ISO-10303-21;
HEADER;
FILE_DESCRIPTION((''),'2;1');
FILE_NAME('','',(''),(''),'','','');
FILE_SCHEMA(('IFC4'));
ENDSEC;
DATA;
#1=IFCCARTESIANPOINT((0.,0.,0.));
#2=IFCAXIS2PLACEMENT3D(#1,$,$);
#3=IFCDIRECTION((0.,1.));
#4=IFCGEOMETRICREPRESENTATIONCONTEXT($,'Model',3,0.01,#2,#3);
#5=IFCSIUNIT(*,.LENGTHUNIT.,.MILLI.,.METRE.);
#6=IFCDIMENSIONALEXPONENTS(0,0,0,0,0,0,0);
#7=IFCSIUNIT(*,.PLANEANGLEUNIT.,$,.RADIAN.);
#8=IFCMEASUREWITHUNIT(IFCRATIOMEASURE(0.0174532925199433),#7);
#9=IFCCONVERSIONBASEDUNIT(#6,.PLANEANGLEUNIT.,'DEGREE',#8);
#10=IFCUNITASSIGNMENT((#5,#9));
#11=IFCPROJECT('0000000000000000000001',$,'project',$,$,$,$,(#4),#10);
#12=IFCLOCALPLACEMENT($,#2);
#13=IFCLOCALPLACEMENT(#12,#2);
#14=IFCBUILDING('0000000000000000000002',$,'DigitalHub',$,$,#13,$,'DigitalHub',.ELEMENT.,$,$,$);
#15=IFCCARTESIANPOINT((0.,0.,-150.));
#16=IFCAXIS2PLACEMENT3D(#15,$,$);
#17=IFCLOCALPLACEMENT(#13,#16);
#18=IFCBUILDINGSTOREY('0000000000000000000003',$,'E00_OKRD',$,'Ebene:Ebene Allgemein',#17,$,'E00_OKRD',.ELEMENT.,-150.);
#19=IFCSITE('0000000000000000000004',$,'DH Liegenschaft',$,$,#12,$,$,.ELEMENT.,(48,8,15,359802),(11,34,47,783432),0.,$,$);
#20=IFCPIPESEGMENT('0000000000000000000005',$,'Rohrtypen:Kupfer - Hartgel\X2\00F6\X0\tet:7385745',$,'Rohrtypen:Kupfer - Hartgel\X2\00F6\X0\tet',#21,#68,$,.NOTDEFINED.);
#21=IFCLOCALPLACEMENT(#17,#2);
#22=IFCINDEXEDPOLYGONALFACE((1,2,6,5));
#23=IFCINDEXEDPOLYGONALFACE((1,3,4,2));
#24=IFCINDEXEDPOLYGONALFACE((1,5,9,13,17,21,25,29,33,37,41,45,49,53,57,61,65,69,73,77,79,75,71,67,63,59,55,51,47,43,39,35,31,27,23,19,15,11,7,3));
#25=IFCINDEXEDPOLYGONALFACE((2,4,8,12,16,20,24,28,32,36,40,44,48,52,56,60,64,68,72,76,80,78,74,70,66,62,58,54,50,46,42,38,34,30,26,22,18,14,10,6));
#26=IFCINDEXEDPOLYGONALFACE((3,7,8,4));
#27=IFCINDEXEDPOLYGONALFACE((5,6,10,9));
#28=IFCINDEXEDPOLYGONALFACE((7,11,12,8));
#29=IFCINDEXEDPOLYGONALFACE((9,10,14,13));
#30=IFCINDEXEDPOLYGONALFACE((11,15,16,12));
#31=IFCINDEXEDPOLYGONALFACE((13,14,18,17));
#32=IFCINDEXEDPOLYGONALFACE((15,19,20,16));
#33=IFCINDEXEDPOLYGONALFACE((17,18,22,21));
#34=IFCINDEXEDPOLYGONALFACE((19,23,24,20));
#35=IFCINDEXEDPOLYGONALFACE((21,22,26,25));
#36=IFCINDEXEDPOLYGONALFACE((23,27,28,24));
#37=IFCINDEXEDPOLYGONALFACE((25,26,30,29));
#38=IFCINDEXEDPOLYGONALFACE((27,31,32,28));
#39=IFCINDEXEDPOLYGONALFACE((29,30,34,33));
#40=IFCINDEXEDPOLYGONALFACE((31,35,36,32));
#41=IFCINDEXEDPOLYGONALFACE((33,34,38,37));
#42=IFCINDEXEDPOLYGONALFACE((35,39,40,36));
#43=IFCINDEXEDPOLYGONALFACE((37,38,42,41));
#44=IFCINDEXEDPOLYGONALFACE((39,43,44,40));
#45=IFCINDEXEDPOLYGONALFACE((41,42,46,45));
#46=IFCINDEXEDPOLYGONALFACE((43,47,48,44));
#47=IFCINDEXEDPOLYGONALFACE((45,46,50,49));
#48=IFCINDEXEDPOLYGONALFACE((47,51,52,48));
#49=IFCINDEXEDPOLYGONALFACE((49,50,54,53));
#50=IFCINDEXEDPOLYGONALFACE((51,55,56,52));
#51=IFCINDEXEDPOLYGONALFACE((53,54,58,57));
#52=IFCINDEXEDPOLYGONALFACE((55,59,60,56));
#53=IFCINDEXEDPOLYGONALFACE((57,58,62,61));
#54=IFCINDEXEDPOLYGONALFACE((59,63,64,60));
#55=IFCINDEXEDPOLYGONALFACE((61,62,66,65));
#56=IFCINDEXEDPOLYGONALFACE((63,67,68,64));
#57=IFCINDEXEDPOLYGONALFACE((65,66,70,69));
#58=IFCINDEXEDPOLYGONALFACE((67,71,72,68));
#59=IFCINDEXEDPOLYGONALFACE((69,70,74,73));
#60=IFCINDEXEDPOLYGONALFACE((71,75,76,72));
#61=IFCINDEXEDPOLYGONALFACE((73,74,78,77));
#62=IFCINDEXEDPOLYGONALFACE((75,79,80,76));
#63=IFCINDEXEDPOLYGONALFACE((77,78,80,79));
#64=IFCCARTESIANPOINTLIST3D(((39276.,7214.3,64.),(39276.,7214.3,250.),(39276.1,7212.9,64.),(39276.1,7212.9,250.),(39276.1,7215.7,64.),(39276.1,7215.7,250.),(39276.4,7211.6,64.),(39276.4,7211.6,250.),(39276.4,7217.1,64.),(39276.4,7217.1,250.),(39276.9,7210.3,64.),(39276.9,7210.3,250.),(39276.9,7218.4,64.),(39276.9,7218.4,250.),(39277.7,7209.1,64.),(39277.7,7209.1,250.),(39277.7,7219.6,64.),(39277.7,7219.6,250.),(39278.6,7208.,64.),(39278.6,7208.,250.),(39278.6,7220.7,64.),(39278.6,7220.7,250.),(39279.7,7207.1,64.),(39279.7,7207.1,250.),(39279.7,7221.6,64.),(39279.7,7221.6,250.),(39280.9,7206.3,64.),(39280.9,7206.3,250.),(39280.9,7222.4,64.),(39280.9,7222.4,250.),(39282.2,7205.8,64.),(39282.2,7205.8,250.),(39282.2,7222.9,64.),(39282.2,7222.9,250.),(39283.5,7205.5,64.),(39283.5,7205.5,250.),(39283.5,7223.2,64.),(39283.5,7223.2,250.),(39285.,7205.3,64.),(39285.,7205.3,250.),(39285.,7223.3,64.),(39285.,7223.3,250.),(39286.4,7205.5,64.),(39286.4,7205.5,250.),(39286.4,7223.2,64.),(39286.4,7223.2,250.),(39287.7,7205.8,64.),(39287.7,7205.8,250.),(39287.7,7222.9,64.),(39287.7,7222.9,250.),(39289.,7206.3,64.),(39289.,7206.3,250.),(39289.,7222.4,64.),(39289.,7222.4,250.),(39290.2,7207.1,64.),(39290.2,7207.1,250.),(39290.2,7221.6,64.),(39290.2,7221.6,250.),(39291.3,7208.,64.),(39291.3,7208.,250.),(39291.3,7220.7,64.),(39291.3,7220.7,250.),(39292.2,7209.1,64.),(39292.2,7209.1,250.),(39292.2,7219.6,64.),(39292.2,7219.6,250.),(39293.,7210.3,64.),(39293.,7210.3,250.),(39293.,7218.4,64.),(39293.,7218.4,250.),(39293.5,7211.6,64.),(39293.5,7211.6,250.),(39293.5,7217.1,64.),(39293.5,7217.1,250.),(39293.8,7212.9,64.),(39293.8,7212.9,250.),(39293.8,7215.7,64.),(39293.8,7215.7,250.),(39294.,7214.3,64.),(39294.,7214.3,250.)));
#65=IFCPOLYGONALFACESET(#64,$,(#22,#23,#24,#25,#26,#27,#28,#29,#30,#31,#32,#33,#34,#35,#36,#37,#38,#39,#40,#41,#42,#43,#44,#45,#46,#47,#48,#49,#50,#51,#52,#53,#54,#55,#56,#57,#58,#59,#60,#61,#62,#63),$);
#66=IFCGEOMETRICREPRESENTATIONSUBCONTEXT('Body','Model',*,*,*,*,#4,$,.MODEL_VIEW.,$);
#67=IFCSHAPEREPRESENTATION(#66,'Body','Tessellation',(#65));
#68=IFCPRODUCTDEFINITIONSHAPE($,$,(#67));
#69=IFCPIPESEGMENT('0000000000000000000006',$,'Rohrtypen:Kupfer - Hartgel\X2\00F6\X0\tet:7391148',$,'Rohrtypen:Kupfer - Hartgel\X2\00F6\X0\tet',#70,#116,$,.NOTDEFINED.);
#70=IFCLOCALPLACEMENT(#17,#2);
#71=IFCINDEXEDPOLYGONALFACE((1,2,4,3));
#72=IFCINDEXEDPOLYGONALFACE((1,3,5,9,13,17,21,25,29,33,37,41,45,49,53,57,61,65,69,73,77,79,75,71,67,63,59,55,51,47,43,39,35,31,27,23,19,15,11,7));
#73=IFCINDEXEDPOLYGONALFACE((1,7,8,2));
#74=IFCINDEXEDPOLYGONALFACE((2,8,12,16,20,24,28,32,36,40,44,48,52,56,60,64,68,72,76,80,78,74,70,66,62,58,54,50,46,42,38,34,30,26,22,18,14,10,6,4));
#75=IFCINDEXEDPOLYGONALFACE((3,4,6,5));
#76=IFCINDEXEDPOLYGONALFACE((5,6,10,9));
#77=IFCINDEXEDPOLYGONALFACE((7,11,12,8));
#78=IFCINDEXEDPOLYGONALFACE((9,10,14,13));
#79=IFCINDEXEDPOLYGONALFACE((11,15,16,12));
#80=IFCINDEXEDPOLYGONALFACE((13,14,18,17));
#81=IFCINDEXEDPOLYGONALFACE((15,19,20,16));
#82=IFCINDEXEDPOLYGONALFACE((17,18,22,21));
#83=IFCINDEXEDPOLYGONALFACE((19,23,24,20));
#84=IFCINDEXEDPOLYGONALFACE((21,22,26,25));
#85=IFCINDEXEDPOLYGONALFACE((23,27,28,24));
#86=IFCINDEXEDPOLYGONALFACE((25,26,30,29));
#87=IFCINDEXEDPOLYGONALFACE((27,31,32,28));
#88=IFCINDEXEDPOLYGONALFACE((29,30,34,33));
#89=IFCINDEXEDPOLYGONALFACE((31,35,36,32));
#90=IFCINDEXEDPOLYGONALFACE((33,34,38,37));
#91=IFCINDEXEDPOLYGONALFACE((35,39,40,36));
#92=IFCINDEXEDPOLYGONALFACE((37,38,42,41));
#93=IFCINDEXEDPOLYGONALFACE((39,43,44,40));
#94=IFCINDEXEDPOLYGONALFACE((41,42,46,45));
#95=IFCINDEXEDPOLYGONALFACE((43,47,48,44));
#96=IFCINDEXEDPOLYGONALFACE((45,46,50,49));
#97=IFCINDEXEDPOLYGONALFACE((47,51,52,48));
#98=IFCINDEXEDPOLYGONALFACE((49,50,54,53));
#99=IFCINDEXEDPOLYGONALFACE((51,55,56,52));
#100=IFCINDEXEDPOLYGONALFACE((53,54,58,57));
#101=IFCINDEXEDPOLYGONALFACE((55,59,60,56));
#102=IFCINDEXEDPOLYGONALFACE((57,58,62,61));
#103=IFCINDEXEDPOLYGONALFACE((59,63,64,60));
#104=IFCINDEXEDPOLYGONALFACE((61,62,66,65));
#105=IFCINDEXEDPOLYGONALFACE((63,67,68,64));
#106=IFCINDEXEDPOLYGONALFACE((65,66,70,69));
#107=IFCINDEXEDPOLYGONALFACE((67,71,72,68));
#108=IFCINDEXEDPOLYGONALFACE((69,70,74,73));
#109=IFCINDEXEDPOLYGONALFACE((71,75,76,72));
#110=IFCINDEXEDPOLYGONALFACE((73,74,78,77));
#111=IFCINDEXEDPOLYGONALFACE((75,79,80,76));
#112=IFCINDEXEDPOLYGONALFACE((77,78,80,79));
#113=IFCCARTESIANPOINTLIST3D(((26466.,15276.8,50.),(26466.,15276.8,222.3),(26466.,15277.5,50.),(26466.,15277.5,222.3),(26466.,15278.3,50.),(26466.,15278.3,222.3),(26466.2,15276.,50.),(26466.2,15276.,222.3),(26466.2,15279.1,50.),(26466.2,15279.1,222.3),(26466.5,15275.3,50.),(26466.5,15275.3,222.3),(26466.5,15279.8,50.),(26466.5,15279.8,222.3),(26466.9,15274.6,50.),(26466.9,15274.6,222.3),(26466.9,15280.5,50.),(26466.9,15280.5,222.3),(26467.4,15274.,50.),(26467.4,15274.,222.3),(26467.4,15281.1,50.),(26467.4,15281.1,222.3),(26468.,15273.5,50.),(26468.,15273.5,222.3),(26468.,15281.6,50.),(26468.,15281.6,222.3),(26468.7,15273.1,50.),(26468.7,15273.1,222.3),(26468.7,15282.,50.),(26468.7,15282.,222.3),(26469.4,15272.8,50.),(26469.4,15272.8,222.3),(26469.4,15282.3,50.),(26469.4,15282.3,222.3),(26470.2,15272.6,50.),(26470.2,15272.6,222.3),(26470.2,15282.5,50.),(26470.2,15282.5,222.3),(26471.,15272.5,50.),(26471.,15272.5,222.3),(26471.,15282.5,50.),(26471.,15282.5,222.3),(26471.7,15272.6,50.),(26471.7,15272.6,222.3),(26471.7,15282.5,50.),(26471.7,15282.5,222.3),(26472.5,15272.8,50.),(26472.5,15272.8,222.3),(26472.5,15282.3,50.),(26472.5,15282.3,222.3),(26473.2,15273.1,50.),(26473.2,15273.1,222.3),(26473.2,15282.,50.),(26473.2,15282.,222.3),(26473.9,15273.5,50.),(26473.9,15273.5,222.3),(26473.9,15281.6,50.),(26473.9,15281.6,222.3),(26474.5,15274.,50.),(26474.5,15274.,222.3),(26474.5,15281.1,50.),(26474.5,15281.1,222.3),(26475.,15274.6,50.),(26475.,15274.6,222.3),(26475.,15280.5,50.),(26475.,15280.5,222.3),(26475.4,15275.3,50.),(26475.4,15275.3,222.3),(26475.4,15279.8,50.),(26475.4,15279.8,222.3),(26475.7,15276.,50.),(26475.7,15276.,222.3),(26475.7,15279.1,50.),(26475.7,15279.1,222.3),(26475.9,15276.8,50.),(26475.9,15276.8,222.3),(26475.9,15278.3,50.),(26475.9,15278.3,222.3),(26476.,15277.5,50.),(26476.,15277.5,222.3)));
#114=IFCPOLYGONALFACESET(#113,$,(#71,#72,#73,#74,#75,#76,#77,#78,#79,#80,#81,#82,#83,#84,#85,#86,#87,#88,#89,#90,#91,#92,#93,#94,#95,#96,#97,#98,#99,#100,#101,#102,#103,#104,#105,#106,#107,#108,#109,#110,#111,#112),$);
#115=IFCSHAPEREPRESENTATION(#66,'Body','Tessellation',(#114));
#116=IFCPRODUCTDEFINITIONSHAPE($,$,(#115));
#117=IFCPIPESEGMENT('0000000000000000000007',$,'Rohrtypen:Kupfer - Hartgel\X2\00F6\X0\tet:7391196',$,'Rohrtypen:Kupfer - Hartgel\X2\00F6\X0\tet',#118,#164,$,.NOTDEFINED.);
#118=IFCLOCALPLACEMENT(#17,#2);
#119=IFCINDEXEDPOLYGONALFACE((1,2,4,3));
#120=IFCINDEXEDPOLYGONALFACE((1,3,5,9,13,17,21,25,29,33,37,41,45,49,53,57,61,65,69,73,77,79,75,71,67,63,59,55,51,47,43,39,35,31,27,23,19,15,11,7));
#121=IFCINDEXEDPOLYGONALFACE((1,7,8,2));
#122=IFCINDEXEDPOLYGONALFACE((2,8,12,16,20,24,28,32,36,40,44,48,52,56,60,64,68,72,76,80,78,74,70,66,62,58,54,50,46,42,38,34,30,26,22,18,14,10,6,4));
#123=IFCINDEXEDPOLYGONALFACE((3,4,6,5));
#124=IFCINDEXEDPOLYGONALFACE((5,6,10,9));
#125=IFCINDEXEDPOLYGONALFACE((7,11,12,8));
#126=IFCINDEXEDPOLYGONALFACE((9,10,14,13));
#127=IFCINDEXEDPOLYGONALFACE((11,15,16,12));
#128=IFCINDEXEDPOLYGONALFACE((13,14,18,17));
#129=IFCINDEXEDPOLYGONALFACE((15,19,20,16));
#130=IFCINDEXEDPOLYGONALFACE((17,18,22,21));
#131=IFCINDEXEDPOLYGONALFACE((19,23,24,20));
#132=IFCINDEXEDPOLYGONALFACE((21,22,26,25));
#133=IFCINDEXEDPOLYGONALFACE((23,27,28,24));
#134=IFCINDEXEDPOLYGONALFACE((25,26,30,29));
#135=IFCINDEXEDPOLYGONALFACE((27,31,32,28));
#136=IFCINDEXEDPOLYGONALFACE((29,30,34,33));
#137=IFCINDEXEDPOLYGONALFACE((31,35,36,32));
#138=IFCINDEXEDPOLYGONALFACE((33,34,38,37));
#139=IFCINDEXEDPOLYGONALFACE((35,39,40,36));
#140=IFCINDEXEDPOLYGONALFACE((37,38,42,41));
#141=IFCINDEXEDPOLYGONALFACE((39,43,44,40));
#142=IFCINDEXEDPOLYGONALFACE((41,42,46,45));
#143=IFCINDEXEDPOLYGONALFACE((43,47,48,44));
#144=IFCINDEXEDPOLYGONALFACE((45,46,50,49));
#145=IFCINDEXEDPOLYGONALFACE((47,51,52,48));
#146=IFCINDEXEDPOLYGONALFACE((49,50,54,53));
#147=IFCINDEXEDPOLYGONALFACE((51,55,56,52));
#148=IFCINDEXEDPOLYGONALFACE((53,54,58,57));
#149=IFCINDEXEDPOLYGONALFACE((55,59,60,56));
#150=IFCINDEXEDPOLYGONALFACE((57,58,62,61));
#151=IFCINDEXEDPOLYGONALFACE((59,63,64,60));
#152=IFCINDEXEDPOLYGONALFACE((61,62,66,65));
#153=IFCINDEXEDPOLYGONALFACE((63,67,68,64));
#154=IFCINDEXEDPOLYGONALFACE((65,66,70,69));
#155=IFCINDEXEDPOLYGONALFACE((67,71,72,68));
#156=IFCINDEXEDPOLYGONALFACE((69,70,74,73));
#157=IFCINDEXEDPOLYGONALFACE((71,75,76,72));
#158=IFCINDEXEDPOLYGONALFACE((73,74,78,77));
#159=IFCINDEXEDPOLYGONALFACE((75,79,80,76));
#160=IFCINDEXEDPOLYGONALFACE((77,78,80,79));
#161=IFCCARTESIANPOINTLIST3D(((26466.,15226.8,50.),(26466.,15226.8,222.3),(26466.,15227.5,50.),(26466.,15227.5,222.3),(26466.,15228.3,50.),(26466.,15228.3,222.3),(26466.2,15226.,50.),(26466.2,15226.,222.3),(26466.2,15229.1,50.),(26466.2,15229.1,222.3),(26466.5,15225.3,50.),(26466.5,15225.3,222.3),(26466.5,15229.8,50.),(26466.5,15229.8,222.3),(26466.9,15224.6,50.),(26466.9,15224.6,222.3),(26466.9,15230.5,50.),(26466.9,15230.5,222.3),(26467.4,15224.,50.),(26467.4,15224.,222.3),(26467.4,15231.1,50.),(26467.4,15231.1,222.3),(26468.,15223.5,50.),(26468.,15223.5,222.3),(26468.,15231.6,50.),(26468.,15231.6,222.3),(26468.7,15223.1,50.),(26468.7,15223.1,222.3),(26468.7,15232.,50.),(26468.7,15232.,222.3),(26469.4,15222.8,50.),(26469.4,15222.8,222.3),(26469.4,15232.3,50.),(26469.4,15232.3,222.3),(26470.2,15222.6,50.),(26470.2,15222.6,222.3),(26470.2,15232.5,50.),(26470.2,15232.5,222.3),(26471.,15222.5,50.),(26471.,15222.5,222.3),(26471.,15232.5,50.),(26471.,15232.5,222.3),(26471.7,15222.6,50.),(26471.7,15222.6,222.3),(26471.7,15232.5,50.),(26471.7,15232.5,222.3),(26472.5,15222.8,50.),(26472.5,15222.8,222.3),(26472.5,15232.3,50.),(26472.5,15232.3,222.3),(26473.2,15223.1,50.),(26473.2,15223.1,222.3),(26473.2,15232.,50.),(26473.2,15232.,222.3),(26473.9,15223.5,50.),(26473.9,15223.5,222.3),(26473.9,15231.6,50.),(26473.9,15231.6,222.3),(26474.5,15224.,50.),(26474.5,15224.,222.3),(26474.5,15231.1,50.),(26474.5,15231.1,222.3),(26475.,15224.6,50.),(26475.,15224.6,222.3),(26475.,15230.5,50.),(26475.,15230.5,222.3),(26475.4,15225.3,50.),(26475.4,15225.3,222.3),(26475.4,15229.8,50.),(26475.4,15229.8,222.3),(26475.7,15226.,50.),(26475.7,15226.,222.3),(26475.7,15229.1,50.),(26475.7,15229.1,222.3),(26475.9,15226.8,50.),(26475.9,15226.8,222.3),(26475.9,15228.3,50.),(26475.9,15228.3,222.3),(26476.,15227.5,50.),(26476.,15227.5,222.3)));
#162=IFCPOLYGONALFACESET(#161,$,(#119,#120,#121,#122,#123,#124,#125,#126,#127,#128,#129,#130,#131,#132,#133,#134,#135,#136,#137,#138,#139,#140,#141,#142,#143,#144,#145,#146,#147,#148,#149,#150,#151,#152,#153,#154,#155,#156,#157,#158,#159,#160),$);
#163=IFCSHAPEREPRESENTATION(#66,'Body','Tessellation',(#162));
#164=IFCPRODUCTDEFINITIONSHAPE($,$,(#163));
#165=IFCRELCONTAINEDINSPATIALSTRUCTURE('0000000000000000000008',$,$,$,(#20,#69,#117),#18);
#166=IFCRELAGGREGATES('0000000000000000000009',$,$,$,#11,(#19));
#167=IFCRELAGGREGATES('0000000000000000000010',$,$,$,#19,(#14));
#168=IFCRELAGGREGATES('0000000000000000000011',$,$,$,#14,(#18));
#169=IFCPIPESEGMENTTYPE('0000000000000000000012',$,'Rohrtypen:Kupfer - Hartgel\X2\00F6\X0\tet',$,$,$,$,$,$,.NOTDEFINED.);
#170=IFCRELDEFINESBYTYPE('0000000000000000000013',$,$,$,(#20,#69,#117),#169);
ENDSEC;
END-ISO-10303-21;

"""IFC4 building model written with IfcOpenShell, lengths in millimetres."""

from ifc_helpers import new_model, entity, si_unit, converted_unit, direction, frame, origin, place, context, subcontext, project, spatial, indexed_curve, outline, extrude, type_object, element, save


model = new_model("IFC4")

# Units and contexts
model_context = context("Model", 3, precision=0.01, world=origin(), true_north=direction((0.0, 1.0)))
body_context = subcontext(model_context, "Body", "Model", "MODEL_VIEW")
ifc_project = project(units=[si_unit("LENGTHUNIT", "METRE", prefix="MILLI"), converted_unit("PLANEANGLEUNIT", "DEGREE", entity("IfcRatioMeasure", 0.0174532925199433), si_unit("PLANEANGLEUNIT", "RADIAN"), dimensions=[0, 0, 0, 0, 0, 0, 0])], contexts=[model_context])

# Site, building, storey
site_placement = place(None, origin())
site = spatial("IfcSite", under=ifc_project, at=site_placement, Name="DH Liegenschaft", CompositionType="ELEMENT", RefLatitude=(48, 8, 15, 359802), RefLongitude=(11, 34, 47, 783432), RefElevation=0.0)
building_placement = place(site_placement, origin())
building = spatial("IfcBuilding", under=site, at=building_placement, Name="DigitalHub", LongName="DigitalHub", CompositionType="ELEMENT")
storey_placement = place(building_placement, frame((0.0, 0.0, -150.0)))
storey = spatial("IfcBuildingStorey", under=building, at=storey_placement, Name="E00_OKRD", ObjectType="Ebene:Ebene Allgemein", LongName="E00_OKRD", CompositionType="ELEMENT", Elevation=-150.0)

# Pipe segments
pipe_segment_type = type_object("IfcPipeSegmentType", Name="Rohrtypen:Kupfer - Hartgelötet", PredefinedType="NOTDEFINED")
pipe_segment_1_placement = place(storey_placement, frame((39274.4, 7203.7, 64.0)))
element("IfcPipeSegment", 1, at=pipe_segment_1_placement, inside=storey, type_object=pipe_segment_type, Name="Rohrtypen:Kupfer - Hartgelötet:7385745", ObjectType="Rohrtypen:Kupfer - Hartgelötet", PredefinedType="NOTDEFINED", context=body_context, shape_type="SweptSolid", body=[
    extrude(outline(indexed_curve([(9.0, 0.0), (8.9, 1.4), (8.6, 2.8), (8.0, 4.1), (7.3, 5.3), (6.4, 6.4), (5.3, 7.3), (4.1, 8.0), (2.8, 8.6), (1.4, 8.9), (0.0, 9.0), (-1.4, 8.9), (-2.8, 8.6), (-4.1, 8.0), (-5.3, 7.3), (-6.4, 6.4), (-7.3, 5.3), (-8.0, 4.1), (-8.6, 2.8), (-8.9, 1.4), (-9.0, 0.0), (-8.9, -1.4), (-8.6, -2.8), (-8.0, -4.1), (-7.3, -5.3), (-6.4, -6.4), (-5.3, -7.3), (-4.1, -8.0), (-2.8, -8.6), (-1.4, -8.9), (0.0, -9.0), (1.4, -8.9), (2.8, -8.6), (4.1, -8.0), (5.3, -7.3), (6.4, -6.4), (7.3, -5.3), (8.0, -4.1), (8.6, -2.8), (8.9, -1.4), (9.0, 0.0)], self_intersect=False)), frame((10.6, 10.6, 0.0)), (0.0, 0.0, 1.0), 186.0),
])
pipe_segment_2_placement = place(storey_placement, frame((26464.4, 15270.9, 50.0)))
element("IfcPipeSegment", 2, at=pipe_segment_2_placement, inside=storey, type_object=pipe_segment_type, Name="Rohrtypen:Kupfer - Hartgelötet:7391148", ObjectType="Rohrtypen:Kupfer - Hartgelötet", PredefinedType="NOTDEFINED", context=body_context, shape_type="SweptSolid", body=[
    extrude(outline(indexed_curve([(5.0, 0.0), (4.9, 0.8), (4.8, 1.5), (4.5, 2.3), (4.0, 2.9), (3.5, 3.5), (2.9, 4.0), (2.3, 4.5), (1.5, 4.8), (0.8, 4.9), (0.0, 5.0), (-0.8, 4.9), (-1.5, 4.8), (-2.3, 4.5), (-2.9, 4.0), (-3.5, 3.5), (-4.0, 2.9), (-4.5, 2.3), (-4.8, 1.5), (-4.9, 0.8), (-5.0, 0.0), (-4.9, -0.8), (-4.8, -1.5), (-4.5, -2.3), (-4.0, -2.9), (-3.5, -3.5), (-2.9, -4.0), (-2.3, -4.5), (-1.5, -4.8), (-0.8, -4.9), (0.0, -5.0), (0.8, -4.9), (1.5, -4.8), (2.3, -4.5), (2.9, -4.0), (3.5, -3.5), (4.0, -2.9), (4.5, -2.3), (4.8, -1.5), (4.9, -0.8), (5.0, 0.0)], self_intersect=False)), frame((6.6, 6.6, 0.0)), (0.0, 0.0, 1.0), 172.3),
])
pipe_segment_3_placement = place(storey_placement, frame((26464.4, 15220.9, 50.0)))
element("IfcPipeSegment", 3, at=pipe_segment_3_placement, inside=storey, type_object=pipe_segment_type, Name="Rohrtypen:Kupfer - Hartgelötet:7391196", ObjectType="Rohrtypen:Kupfer - Hartgelötet", PredefinedType="NOTDEFINED", context=body_context, shape_type="SweptSolid", body=[
    extrude(outline(indexed_curve([(5.0, 0.0), (4.9, 0.8), (4.8, 1.5), (4.5, 2.3), (4.0, 2.9), (3.5, 3.5), (2.9, 4.0), (2.3, 4.5), (1.5, 4.8), (0.8, 4.9), (0.0, 5.0), (-0.8, 4.9), (-1.5, 4.8), (-2.3, 4.5), (-2.9, 4.0), (-3.5, 3.5), (-4.0, 2.9), (-4.5, 2.3), (-4.8, 1.5), (-4.9, 0.8), (-5.0, 0.0), (-4.9, -0.8), (-4.8, -1.5), (-4.5, -2.3), (-4.0, -2.9), (-3.5, -3.5), (-2.9, -4.0), (-2.3, -4.5), (-1.5, -4.8), (-0.8, -4.9), (0.0, -5.0), (0.8, -4.9), (1.5, -4.8), (2.3, -4.5), (2.9, -4.0), (3.5, -3.5), (4.0, -2.9), (4.5, -2.3), (4.8, -1.5), (4.9, -0.8), (5.0, 0.0)], self_intersect=False)), frame((6.6, 6.6, 0.0)), (0.0, 0.0, 1.0), 172.3),
])

save(model, "model.ifc")
